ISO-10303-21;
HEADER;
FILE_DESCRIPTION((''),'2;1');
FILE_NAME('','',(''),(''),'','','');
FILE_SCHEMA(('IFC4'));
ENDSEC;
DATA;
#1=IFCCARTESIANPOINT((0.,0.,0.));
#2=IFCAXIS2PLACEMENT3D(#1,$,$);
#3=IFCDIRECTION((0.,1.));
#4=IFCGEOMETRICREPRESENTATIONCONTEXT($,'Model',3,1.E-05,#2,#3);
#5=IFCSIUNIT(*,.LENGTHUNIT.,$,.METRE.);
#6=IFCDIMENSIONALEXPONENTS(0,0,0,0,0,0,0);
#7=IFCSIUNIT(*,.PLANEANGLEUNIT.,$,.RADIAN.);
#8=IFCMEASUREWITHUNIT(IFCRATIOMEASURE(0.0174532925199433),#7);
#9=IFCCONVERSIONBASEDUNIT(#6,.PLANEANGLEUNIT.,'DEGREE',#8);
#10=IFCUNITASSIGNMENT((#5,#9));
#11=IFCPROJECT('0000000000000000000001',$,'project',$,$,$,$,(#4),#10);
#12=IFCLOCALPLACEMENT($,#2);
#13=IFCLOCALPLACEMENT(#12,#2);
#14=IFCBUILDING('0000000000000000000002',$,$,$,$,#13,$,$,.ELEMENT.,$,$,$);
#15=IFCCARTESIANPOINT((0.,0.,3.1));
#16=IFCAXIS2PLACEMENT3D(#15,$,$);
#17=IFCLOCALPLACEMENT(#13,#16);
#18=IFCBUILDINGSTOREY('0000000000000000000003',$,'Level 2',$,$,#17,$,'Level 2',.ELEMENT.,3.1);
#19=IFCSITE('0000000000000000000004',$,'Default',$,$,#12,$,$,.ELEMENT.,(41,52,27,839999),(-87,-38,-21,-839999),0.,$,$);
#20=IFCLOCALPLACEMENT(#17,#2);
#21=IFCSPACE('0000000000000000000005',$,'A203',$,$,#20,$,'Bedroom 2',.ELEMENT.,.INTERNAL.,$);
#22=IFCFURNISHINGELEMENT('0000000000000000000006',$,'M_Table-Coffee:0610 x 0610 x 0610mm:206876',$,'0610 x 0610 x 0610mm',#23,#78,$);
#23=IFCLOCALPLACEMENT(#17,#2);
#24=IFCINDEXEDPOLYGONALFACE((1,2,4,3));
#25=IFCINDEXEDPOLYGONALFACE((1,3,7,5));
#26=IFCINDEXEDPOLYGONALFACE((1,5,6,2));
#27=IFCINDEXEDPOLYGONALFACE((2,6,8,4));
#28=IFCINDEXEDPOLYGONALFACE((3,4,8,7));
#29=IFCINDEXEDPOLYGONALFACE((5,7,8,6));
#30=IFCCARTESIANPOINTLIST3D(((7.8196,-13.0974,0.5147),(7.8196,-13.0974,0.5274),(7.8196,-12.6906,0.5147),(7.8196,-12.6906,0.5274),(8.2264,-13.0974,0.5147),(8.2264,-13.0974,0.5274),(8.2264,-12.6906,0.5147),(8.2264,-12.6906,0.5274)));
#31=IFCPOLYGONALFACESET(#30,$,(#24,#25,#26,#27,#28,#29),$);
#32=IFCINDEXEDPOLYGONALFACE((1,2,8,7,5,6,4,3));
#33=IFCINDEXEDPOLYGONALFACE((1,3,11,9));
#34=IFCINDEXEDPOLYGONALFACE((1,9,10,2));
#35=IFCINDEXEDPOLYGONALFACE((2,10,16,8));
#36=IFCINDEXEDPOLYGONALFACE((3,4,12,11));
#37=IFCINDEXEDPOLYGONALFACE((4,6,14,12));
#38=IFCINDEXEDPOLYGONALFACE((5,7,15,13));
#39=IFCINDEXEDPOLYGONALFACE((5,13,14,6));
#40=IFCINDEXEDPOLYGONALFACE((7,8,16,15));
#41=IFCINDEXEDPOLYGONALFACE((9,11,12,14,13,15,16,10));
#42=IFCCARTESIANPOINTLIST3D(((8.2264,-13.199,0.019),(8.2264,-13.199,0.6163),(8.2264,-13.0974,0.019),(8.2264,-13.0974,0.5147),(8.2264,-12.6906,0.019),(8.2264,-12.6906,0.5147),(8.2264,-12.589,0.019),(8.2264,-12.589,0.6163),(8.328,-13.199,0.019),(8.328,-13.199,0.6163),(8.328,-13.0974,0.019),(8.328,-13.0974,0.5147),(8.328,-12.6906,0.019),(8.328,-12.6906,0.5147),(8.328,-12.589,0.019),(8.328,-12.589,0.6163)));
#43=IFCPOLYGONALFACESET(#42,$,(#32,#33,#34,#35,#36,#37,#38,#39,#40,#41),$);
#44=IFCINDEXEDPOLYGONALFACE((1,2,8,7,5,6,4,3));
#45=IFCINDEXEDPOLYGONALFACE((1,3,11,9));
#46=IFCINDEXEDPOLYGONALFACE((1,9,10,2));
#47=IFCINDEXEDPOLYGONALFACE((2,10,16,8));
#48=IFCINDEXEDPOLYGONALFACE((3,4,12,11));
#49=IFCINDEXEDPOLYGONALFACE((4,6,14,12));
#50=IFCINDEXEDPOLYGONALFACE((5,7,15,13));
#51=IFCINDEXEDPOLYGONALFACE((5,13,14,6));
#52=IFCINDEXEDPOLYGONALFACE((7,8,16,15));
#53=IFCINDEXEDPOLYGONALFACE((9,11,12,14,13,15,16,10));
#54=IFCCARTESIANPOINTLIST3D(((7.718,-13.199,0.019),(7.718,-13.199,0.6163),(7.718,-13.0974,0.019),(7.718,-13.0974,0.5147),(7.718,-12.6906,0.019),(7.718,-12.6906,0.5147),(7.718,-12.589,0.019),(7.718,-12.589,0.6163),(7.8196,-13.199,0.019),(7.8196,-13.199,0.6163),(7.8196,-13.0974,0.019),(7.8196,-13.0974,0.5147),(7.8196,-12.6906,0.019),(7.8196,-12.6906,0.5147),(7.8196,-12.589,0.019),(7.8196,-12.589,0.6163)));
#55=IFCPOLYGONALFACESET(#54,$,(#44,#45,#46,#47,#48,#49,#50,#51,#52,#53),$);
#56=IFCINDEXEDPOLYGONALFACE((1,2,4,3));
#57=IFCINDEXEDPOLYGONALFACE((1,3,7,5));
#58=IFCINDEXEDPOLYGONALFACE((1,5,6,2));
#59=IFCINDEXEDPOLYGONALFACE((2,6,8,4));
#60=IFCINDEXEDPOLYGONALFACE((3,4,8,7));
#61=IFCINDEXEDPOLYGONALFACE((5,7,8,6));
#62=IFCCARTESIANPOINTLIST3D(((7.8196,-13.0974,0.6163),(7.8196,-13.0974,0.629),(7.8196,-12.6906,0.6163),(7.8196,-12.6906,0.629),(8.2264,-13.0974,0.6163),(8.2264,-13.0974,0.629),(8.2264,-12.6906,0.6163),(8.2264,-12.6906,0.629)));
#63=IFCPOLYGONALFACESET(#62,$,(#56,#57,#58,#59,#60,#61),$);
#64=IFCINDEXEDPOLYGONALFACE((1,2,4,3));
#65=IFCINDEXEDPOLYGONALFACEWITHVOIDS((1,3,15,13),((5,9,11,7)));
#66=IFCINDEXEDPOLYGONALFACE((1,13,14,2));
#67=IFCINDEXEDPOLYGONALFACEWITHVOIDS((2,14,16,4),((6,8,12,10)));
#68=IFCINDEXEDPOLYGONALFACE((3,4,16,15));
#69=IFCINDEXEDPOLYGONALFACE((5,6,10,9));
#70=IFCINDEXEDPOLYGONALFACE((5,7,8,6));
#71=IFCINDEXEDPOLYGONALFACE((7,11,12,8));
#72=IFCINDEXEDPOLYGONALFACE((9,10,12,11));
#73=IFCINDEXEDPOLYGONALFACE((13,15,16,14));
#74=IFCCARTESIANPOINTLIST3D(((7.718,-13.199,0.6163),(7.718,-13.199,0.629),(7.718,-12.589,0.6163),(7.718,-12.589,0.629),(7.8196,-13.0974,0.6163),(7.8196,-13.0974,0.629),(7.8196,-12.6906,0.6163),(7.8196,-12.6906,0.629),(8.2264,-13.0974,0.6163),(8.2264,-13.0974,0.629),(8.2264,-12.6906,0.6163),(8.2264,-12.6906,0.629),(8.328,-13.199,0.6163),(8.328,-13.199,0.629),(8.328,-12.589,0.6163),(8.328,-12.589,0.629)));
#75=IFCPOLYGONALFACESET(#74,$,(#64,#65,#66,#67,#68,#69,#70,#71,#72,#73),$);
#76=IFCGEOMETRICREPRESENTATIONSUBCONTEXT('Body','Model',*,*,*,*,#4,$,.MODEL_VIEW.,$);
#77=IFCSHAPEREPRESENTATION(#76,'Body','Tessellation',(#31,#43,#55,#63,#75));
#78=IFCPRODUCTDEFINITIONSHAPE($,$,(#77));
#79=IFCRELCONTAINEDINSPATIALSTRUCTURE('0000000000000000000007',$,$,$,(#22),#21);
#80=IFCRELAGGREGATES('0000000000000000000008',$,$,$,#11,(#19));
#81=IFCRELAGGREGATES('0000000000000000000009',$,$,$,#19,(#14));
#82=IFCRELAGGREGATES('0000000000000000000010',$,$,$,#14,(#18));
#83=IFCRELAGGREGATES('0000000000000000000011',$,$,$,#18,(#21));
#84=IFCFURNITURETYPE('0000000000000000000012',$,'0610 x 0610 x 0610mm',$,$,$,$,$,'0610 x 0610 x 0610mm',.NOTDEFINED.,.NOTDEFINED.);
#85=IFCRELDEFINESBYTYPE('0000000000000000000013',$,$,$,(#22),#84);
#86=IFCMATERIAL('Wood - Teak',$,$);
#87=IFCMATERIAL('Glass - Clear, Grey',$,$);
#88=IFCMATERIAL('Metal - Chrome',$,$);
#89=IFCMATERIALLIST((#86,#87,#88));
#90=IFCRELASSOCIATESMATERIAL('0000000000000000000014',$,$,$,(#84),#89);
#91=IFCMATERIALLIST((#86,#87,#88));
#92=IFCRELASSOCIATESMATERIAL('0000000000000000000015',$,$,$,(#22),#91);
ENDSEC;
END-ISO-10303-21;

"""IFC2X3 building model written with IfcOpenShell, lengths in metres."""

from ifc_helpers import new_model, entity, si_unit, converted_unit, direction, frame, origin, origin_2d_with_axis, place, context, subcontext, project, spatial, polyline, rectangle, outline, extrude, source, transform, mapped, material, material_list, type_object, type_shapes, element, save


model = new_model("IFC2X3")

# Units and contexts
model_context = context("Model", 3, precision=1e-05, world=origin(), true_north=direction((0.0, 1.0)))
body_context = subcontext(model_context, "Body", "Model", "MODEL_VIEW")
ifc_project = project(units=[si_unit("LENGTHUNIT", "METRE"), converted_unit("PLANEANGLEUNIT", "DEGREE", entity("IfcRatioMeasure", 0.0174532925199433), si_unit("PLANEANGLEUNIT", "RADIAN"), dimensions=[0, 0, 0, 0, 0, 0, 0])], contexts=[model_context])

# Site, building, storey
site_placement = place(None, origin())
site = spatial("IfcSite", under=ifc_project, at=site_placement, Name="Default", CompositionType="ELEMENT", RefLatitude=(41, 52, 27, 839999), RefLongitude=(-87, -38, -21, -839999), RefElevation=0.0)
building_placement = place(site_placement, origin())
building = spatial("IfcBuilding", under=site, at=building_placement, CompositionType="ELEMENT")
storey_placement = place(building_placement, frame((0.0, 0.0, 3.1)))
storey = spatial("IfcBuildingStorey", under=building, at=storey_placement, Name="Level 2", LongName="Level 2", CompositionType="ELEMENT", Elevation=3.1)

# Shared definitions
space_1_placement = place(storey_placement, origin())
space_1 = spatial("IfcSpace", under=storey, at=space_1_placement, Name="A203", LongName="Bedroom 2", CompositionType="ELEMENT", InteriorOrExteriorSpace="INTERNAL")

# Furnishing element
ifc_material_1 = material(Name="Wood - Teak")
ifc_material_2 = material(Name="Glass - Clear, Grey")
ifc_material_3 = material(Name="Metal - Chrome")
ifc_material_list_1 = material_list([ifc_material_1, ifc_material_2, ifc_material_3])
ifc_material_list_2 = material_list([ifc_material_1, ifc_material_2, ifc_material_3])
furniture_type_1 = type_object("IfcFurnitureType", Name="0610 x 0610 x 0610mm", ElementType="0610 x 0610 x 0610mm", AssemblyPlace="NOTDEFINED", material=ifc_material_list_2)
shared_shape_1 = source(origin(), body_context, "Body", "SweptSolid", [
    extrude(rectangle(XDim=0.4068, YDim=0.4068, at=origin_2d_with_axis()), frame((0.0183, 0.0952, 0.4957), z_axis=(0.0, 0.0, 1.0), x_axis=(-1.0, 0.0, 0.0)), (0.0, 0.0, 1.0), 0.0127),
    extrude(outline(polyline([(-0.2732, -0.305), (0.324, -0.305), (0.324, 0.305), (-0.2732, 0.305), (-0.2732, 0.2034), (0.2225, 0.2034), (0.2225, -0.2034), (-0.2732, -0.2034), (-0.2732, -0.305)])), frame((0.2217, 0.0952, 0.2732), z_axis=(1.0, 0.0, 0.0), x_axis=(0.0, 0.0, 1.0)), (0.0, 0.0, 1.0), 0.1016),
    extrude(outline(polyline([(-0.305, -0.3241), (0.305, -0.3241), (0.305, 0.2733), (0.2034, 0.2733), (0.2034, -0.2224), (-0.2034, -0.2224), (-0.2034, 0.2733), (-0.305, 0.2733), (-0.305, -0.3241)])), frame((-0.2867, 0.0952, 0.2733), z_axis=(1.0, 0.0, 0.0), x_axis=(0.0, -1.0, 0.0)), (0.0, 0.0, 1.0), 0.1016),
    extrude(rectangle(XDim=0.4068, YDim=0.4068, at=origin_2d_with_axis()), frame((0.0183, 0.0952, 0.5973), z_axis=(0.0, 0.0, 1.0), x_axis=(-1.0, 0.0, 0.0)), (0.0, 0.0, 1.0), 0.0127),
    extrude(outline(polyline([(-0.305, -0.305), (0.305, -0.305), (0.305, 0.305), (-0.305, 0.305), (-0.305, -0.305)]), holes=[polyline([(-0.2034, -0.2034), (-0.2034, 0.2034), (0.2034, 0.2034), (0.2034, -0.2034), (-0.2034, -0.2034)])]), frame((0.0183, 0.0952, 0.5973), z_axis=(0.0, 0.0, 1.0), x_axis=(-1.0, 0.0, 0.0)), (0.0, 0.0, 1.0), 0.0127),
])
type_shapes(furniture_type_1, [shared_shape_1])
furnishing_1_placement = place(space_1_placement, frame((8.0047, -12.9892, 0.019)))
element("IfcFurnishingElement", 1, at=furnishing_1_placement, inside=space_1, type_object=furniture_type_1, material=ifc_material_list_1, Name="M_Table-Coffee:0610 x 0610 x 0610mm:206876", ObjectType="0610 x 0610 x 0610mm", context=body_context, shape_type="MappedRepresentation", body=[
    mapped(shared_shape_1, transform((0.0, 0.0, 0.0), scale=1.0)),
])

save(model, "model.ifc")
